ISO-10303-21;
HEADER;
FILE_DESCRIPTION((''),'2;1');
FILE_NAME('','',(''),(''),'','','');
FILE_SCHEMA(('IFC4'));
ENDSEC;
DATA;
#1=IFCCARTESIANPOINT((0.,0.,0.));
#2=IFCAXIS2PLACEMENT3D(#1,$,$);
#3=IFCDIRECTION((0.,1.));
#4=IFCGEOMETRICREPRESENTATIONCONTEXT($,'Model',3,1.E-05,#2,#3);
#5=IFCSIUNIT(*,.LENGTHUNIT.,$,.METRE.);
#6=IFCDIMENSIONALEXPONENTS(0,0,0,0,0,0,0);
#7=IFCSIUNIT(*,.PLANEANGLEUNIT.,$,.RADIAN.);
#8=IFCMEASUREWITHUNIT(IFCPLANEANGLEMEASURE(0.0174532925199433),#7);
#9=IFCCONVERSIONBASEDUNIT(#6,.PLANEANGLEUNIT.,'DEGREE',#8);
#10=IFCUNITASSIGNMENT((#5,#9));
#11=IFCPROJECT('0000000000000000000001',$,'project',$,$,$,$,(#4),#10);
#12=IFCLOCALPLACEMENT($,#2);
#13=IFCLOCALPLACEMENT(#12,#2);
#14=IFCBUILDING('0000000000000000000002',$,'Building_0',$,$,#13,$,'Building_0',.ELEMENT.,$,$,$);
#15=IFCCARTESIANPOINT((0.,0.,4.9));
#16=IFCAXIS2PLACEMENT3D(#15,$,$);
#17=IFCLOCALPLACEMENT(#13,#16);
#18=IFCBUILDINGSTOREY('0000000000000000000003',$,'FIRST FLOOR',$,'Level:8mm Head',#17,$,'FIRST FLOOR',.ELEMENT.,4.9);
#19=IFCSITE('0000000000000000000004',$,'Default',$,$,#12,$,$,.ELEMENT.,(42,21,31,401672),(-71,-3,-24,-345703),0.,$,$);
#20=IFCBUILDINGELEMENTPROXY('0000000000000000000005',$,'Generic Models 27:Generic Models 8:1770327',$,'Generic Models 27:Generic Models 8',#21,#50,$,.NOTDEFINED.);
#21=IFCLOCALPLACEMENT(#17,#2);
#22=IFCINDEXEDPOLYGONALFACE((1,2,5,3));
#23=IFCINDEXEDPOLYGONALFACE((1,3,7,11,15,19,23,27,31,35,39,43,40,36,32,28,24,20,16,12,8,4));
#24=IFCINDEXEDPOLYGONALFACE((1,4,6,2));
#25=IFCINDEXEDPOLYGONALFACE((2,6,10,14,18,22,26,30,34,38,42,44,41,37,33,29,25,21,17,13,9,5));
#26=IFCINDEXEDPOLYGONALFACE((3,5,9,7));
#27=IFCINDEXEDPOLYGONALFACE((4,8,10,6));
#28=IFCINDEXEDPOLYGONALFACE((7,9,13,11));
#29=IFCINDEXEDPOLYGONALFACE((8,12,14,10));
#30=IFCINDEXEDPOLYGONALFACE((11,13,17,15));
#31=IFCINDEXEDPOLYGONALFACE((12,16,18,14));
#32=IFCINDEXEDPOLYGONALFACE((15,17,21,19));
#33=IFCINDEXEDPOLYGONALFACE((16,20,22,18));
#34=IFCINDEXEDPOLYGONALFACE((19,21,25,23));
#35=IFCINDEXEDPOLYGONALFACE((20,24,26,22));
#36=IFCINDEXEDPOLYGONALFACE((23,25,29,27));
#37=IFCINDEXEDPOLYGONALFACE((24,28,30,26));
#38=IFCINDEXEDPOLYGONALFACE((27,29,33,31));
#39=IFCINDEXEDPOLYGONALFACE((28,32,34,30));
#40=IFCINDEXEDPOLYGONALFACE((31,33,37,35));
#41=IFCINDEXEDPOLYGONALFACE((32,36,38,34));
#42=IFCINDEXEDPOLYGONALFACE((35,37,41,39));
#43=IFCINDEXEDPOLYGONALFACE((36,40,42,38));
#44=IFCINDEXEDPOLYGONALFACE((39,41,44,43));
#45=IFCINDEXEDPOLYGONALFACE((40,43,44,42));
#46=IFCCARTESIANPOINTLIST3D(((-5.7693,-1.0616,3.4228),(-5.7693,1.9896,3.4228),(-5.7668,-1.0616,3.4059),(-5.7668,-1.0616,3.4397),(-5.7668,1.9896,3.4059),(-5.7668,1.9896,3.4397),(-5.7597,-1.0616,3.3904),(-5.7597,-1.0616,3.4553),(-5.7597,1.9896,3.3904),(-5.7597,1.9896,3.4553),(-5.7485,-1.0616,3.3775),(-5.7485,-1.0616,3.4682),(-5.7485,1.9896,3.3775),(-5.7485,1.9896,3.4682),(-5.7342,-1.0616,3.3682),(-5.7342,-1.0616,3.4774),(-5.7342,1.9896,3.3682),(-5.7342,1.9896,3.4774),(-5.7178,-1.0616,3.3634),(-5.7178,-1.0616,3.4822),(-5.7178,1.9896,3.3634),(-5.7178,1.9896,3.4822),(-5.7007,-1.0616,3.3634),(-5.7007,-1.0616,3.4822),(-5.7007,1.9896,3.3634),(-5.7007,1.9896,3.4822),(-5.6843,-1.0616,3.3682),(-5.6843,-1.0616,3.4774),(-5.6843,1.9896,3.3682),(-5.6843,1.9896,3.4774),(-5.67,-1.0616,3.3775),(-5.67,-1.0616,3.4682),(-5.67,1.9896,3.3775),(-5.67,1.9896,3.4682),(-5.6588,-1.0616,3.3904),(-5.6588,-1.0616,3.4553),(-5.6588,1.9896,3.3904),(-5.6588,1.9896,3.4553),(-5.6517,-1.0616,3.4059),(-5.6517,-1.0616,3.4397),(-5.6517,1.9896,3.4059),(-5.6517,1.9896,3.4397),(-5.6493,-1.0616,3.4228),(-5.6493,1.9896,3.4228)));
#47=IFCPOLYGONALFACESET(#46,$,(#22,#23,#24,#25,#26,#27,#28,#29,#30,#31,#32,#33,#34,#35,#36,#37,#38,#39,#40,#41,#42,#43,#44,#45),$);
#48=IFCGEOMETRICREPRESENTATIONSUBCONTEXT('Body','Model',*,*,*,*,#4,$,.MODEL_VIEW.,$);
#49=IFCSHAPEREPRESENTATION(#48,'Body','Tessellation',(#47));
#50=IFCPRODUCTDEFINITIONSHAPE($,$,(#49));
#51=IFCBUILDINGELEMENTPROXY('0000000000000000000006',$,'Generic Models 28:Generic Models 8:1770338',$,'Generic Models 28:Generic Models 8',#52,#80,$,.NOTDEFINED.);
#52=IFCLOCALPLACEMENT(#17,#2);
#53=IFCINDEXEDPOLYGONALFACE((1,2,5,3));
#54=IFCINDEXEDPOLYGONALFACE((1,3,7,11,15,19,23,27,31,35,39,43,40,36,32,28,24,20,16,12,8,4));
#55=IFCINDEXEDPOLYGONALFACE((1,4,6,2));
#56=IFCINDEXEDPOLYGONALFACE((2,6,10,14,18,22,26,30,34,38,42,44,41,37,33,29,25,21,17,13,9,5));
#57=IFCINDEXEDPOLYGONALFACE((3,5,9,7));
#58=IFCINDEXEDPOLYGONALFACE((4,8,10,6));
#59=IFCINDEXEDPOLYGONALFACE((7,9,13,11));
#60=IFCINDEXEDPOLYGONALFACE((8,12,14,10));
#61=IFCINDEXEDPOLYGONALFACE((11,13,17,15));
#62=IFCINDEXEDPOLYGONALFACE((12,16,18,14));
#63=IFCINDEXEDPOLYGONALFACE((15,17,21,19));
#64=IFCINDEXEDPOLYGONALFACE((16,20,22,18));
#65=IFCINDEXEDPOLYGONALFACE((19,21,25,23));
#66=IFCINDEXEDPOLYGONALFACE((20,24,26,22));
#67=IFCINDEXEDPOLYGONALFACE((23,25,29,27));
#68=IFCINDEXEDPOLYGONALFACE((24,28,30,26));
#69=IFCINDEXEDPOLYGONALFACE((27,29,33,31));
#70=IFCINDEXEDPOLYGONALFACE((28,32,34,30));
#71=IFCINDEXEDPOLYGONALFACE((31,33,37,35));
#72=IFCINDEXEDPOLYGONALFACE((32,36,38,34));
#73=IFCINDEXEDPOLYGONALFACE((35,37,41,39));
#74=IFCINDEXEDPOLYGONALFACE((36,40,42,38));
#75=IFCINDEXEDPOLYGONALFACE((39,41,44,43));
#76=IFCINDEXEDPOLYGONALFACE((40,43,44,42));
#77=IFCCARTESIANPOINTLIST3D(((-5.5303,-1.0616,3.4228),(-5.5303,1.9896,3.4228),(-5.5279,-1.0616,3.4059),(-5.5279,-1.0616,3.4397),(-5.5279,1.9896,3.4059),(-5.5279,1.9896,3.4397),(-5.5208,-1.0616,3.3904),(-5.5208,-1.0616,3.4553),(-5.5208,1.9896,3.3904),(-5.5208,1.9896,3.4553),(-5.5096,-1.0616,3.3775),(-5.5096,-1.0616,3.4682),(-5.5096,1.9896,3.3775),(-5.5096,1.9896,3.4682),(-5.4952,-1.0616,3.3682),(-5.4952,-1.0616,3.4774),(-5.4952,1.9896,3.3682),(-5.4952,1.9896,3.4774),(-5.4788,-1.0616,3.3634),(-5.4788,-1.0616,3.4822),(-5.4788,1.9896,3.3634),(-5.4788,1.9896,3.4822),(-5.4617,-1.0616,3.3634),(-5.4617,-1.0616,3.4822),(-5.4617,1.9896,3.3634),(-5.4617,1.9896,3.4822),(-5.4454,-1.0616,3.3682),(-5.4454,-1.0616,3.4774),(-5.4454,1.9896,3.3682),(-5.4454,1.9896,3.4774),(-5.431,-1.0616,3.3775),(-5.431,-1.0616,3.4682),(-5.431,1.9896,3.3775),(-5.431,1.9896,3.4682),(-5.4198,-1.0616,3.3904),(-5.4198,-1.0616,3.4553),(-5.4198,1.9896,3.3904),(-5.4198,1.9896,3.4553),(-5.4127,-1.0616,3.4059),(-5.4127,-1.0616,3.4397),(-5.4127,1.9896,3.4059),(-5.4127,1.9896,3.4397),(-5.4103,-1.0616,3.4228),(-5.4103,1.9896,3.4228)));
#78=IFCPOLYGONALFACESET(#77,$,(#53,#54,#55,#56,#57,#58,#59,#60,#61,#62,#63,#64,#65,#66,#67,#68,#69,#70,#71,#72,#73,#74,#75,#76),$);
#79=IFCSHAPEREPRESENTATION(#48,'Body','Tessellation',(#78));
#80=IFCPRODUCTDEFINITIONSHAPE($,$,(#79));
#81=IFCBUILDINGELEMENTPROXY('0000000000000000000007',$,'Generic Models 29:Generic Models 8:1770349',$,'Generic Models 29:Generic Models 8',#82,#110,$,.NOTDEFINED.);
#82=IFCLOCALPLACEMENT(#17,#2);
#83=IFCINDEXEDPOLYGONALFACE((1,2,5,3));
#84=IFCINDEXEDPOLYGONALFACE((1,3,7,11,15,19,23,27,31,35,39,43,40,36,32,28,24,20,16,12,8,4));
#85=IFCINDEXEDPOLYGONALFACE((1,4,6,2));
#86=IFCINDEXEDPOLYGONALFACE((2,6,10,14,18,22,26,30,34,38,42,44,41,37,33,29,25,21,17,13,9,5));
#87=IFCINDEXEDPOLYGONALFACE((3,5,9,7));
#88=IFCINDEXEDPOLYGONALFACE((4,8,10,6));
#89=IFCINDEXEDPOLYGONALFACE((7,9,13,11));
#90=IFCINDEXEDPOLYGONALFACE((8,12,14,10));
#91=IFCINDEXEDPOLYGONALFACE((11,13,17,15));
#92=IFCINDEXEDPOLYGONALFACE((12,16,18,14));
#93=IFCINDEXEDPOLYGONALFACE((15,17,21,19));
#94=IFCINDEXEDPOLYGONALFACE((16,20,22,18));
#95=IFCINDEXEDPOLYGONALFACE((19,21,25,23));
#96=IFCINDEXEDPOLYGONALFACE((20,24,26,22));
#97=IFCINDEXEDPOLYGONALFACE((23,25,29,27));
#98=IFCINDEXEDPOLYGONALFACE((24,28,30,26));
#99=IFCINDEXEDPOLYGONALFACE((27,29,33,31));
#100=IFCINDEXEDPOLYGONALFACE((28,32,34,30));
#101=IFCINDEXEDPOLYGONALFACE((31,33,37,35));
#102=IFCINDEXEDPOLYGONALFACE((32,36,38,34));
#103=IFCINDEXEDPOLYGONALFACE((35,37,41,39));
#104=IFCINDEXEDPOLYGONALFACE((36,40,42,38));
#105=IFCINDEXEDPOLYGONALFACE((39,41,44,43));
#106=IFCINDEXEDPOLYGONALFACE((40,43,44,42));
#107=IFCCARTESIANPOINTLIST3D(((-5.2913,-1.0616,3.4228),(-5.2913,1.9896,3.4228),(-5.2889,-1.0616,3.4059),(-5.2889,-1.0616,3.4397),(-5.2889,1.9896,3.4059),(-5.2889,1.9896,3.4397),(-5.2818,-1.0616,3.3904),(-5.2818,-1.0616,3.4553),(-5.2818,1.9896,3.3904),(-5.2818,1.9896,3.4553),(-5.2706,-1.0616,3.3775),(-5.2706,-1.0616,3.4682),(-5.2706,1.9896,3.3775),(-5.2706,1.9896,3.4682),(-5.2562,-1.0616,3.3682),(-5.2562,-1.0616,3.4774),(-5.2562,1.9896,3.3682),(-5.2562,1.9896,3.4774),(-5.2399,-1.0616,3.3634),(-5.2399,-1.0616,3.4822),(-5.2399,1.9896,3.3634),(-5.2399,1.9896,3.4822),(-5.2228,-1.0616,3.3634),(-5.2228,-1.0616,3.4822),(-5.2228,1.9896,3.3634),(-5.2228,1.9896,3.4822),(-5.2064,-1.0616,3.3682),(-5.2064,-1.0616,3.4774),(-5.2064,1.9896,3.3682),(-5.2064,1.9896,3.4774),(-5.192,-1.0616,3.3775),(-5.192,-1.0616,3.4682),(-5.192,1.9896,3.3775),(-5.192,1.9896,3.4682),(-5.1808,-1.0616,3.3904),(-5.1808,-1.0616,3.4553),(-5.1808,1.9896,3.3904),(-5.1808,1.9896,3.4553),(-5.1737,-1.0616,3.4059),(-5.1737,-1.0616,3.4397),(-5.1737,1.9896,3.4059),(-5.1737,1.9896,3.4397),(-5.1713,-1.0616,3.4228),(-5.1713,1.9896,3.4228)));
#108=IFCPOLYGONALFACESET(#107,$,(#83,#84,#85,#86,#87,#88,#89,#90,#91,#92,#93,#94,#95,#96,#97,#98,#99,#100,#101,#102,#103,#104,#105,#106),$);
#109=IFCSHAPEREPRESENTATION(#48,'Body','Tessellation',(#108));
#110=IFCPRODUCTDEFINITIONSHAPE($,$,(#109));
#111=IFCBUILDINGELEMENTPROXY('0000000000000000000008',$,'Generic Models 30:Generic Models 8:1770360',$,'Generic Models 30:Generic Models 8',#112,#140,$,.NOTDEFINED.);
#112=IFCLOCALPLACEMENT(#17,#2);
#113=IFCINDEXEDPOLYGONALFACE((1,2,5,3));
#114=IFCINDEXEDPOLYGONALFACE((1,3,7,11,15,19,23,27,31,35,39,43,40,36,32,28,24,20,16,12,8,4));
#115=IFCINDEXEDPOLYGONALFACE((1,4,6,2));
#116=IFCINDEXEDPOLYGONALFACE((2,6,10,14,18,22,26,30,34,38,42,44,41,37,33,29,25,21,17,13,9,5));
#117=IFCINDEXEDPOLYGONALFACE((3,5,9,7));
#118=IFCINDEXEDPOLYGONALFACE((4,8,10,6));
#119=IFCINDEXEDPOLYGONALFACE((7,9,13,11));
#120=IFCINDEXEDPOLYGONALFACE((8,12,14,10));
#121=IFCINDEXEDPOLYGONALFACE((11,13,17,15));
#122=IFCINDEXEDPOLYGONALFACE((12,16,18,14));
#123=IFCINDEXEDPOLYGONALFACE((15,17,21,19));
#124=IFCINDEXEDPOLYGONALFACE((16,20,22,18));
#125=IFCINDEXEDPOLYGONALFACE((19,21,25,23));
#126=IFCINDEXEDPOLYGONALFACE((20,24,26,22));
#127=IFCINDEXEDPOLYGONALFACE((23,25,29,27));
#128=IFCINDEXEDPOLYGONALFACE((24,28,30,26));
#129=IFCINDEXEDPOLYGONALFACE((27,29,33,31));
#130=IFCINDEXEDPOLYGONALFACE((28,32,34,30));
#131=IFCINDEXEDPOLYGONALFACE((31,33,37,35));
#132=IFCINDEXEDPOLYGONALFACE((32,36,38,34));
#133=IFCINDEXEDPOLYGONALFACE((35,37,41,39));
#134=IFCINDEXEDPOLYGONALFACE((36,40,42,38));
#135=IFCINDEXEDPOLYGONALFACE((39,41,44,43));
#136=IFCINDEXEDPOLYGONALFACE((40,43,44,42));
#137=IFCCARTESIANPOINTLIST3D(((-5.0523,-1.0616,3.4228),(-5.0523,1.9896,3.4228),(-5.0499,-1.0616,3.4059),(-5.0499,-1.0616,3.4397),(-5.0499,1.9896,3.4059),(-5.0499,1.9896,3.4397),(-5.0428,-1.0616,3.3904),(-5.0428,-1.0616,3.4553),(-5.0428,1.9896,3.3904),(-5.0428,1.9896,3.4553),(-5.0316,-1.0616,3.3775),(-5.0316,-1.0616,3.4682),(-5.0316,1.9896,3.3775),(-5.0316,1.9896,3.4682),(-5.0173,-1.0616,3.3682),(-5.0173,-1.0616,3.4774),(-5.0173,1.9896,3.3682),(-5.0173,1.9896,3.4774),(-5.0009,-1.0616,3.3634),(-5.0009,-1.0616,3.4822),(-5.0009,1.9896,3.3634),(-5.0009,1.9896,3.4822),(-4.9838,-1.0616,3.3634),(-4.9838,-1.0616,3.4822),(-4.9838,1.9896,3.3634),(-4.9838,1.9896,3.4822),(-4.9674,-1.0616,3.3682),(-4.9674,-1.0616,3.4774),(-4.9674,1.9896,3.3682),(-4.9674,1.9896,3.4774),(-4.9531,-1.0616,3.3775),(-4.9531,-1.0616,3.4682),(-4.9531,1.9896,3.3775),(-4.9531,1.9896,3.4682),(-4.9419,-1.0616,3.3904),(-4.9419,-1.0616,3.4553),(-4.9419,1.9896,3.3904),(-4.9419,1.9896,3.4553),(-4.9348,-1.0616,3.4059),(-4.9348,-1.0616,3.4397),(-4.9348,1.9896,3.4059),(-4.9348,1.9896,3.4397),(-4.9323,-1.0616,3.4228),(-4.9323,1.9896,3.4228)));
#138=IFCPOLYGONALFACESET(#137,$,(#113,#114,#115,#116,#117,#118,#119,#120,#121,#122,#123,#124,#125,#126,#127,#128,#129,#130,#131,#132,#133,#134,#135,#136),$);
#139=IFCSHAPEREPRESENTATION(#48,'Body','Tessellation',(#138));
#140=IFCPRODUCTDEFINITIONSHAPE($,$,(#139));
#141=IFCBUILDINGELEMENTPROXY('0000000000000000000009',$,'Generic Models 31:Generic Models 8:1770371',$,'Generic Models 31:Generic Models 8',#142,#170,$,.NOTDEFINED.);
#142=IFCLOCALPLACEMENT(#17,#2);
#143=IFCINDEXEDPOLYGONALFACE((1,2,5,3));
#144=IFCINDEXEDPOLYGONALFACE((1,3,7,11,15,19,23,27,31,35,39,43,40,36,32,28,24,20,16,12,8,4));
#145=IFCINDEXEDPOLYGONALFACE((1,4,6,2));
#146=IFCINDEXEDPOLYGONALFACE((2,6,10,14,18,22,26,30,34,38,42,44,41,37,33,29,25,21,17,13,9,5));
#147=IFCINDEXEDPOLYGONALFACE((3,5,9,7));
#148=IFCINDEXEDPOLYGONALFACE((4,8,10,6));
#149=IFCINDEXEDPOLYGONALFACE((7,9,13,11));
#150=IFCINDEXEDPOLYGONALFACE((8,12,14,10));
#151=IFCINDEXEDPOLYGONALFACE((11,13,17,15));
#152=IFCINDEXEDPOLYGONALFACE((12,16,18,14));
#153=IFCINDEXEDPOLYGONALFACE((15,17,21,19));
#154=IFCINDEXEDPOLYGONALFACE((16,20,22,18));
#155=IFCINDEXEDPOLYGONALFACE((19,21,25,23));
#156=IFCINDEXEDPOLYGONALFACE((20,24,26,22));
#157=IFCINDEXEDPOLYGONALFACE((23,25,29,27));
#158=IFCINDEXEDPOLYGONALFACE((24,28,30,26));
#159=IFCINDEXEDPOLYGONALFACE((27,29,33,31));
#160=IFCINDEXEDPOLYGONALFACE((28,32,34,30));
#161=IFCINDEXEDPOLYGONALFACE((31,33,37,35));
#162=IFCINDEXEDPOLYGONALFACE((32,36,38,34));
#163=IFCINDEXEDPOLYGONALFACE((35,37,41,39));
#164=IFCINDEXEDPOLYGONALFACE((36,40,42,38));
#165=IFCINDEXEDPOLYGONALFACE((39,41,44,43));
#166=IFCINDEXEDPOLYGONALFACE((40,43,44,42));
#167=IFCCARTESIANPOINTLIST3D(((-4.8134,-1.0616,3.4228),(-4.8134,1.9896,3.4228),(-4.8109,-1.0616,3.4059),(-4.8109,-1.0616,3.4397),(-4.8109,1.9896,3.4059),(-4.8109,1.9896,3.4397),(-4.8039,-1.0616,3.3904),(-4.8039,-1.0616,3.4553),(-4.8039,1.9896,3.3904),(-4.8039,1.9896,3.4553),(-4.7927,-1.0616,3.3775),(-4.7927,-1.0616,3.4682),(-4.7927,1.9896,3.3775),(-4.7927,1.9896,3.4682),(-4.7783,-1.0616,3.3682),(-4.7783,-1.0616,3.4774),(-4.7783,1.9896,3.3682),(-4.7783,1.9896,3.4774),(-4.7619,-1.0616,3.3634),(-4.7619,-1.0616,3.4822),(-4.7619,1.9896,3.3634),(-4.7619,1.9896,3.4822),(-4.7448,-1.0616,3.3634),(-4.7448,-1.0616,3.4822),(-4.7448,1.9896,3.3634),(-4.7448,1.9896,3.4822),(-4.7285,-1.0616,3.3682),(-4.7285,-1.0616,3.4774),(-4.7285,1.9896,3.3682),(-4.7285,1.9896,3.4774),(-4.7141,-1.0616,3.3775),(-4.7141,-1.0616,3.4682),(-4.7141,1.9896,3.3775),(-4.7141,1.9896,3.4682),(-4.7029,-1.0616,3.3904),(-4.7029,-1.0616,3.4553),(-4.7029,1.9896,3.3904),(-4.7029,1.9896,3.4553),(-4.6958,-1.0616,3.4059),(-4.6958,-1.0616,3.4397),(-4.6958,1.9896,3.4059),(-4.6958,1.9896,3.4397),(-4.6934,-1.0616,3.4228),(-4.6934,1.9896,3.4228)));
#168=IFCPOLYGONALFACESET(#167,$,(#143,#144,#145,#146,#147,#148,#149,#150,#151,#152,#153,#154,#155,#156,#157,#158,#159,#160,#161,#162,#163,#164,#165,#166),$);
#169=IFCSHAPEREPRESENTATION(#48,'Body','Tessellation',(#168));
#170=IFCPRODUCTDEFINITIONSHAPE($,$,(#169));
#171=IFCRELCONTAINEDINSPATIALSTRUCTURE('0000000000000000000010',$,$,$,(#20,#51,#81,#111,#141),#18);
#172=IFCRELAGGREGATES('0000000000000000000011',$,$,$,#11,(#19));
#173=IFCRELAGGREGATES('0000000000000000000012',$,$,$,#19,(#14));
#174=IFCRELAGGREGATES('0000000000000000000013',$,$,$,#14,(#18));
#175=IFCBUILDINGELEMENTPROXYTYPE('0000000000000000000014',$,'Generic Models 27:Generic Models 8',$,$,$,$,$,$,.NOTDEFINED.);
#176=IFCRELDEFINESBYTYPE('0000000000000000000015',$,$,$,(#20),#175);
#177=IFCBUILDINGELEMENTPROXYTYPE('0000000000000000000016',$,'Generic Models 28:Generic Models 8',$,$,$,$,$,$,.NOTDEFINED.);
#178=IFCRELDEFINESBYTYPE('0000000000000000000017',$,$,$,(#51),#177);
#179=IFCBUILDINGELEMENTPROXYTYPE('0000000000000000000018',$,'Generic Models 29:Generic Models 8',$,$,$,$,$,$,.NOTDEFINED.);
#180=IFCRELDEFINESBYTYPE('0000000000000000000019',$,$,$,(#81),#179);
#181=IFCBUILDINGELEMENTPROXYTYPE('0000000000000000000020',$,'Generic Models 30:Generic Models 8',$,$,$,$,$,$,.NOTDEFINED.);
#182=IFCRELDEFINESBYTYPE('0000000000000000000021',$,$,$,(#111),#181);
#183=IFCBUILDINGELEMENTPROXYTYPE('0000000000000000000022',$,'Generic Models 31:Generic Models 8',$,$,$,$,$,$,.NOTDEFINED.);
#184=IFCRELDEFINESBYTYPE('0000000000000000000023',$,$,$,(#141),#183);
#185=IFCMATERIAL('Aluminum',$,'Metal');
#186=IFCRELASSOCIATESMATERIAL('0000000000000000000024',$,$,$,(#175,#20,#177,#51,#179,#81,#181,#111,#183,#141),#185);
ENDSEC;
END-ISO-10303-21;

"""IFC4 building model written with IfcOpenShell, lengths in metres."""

from ifc_helpers import new_model, entity, si_unit, converted_unit, direction, frame, origin, place, context, subcontext, project, spatial, arc, indexed_curve, outline, extrude, source, transform, mapped, material, type_object, type_shapes, element, save


model = new_model("IFC4")

# Units and contexts
model_context = context("Model", 3, precision=1e-05, world=origin(), true_north=direction((0.0, 1.0)))
body_context = subcontext(model_context, "Body", "Model", "MODEL_VIEW")
ifc_project = project(units=[si_unit("LENGTHUNIT", "METRE"), converted_unit("PLANEANGLEUNIT", "DEGREE", entity("IfcPlaneAngleMeasure", 0.0174532925199433), si_unit("PLANEANGLEUNIT", "RADIAN"), dimensions=[0, 0, 0, 0, 0, 0, 0])], contexts=[model_context])

# Site, building, storey
site_placement = place(None, origin())
site = spatial("IfcSite", under=ifc_project, at=site_placement, Name="Default", CompositionType="ELEMENT", RefLatitude=(42, 21, 31, 401672), RefLongitude=(-71, -3, -24, -345703), RefElevation=0.0)
building_placement = place(site_placement, origin())
building = spatial("IfcBuilding", under=site, at=building_placement, Name="Building_0", LongName="Building_0", CompositionType="ELEMENT")
storey_placement = place(building_placement, frame((0.0, 0.0, 4.9)))
storey = spatial("IfcBuildingStorey", under=building, at=storey_placement, Name="FIRST FLOOR", ObjectType="Level:8mm Head", LongName="FIRST FLOOR", CompositionType="ELEMENT", Elevation=4.9)

# Building element proxies
ifc_material = material(Name="Aluminum", Category="Metal")
building_element_proxy_type_1 = type_object("IfcBuildingElementProxyType", Name="Generic Models 27:Generic Models 8", PredefinedType="NOTDEFINED", material=ifc_material)
shared_shape_1 = source(origin(), body_context, "Body", "SweptSolid", [
    extrude(outline(indexed_curve([(-0.06, 0.0), (0.0, -0.06), (0.06, 0.0), (0.0, 0.06)], segments=[arc(1, 2, 3), arc(3, 4, 1)], self_intersect=False)), frame((-5.7093, -1.0616, 8.3228), z_axis=(0.0, 1.0, 0.0), x_axis=(-1.0, 0.0, 0.0)), (0.0, 0.0, 1.0), 3.0512),
])
type_shapes(building_element_proxy_type_1, [shared_shape_1])
proxy_1_placement = place(storey_placement, frame((0.0, 0.0, -4.9)))
element("IfcBuildingElementProxy", 1, at=proxy_1_placement, inside=storey, type_object=building_element_proxy_type_1, material=ifc_material, Name="Generic Models 27:Generic Models 8:1770327", ObjectType="Generic Models 27:Generic Models 8", PredefinedType="NOTDEFINED", context=body_context, shape_type="MappedRepresentation", body=[
    mapped(shared_shape_1, transform((0.0, 0.0, 0.0), scale=1.0)),
])
building_element_proxy_type_2 = type_object("IfcBuildingElementProxyType", Name="Generic Models 28:Generic Models 8", PredefinedType="NOTDEFINED", material=ifc_material)
shared_shape_2 = source(origin(), body_context, "Body", "SweptSolid", [
    extrude(outline(indexed_curve([(-0.06, 0.0), (0.0, -0.06), (0.06, 0.0), (0.0, 0.06)], segments=[arc(1, 2, 3), arc(3, 4, 1)], self_intersect=False)), frame((-5.4703, -1.0616, 8.3228), z_axis=(0.0, 1.0, 0.0), x_axis=(-1.0, 0.0, 0.0)), (0.0, 0.0, 1.0), 3.0512),
])
type_shapes(building_element_proxy_type_2, [shared_shape_2])
proxy_2_placement = place(storey_placement, frame((0.0, 0.0, -4.9)))
element("IfcBuildingElementProxy", 2, at=proxy_2_placement, inside=storey, type_object=building_element_proxy_type_2, material=ifc_material, Name="Generic Models 28:Generic Models 8:1770338", ObjectType="Generic Models 28:Generic Models 8", PredefinedType="NOTDEFINED", context=body_context, shape_type="MappedRepresentation", body=[
    mapped(shared_shape_2, transform((0.0, 0.0, 0.0), scale=1.0)),
])
building_element_proxy_type_3 = type_object("IfcBuildingElementProxyType", Name="Generic Models 29:Generic Models 8", PredefinedType="NOTDEFINED", material=ifc_material)
shared_shape_3 = source(origin(), body_context, "Body", "SweptSolid", [
    extrude(outline(indexed_curve([(-0.06, 0.0), (0.0, -0.06), (0.06, 0.0), (0.0, 0.06)], segments=[arc(1, 2, 3), arc(3, 4, 1)], self_intersect=False)), frame((-5.2313, -1.0616, 8.3228), z_axis=(0.0, 1.0, 0.0), x_axis=(-1.0, 0.0, 0.0)), (0.0, 0.0, 1.0), 3.0512),
])
type_shapes(building_element_proxy_type_3, [shared_shape_3])
proxy_3_placement = place(storey_placement, frame((0.0, 0.0, -4.9)))
element("IfcBuildingElementProxy", 3, at=proxy_3_placement, inside=storey, type_object=building_element_proxy_type_3, material=ifc_material, Name="Generic Models 29:Generic Models 8:1770349", ObjectType="Generic Models 29:Generic Models 8", PredefinedType="NOTDEFINED", context=body_context, shape_type="MappedRepresentation", body=[
    mapped(shared_shape_3, transform((0.0, 0.0, 0.0), scale=1.0)),
])
building_element_proxy_type_4 = type_object("IfcBuildingElementProxyType", Name="Generic Models 30:Generic Models 8", PredefinedType="NOTDEFINED", material=ifc_material)
shared_shape_4 = source(origin(), body_context, "Body", "SweptSolid", [
    extrude(outline(indexed_curve([(-0.06, 0.0), (0.0, -0.06), (0.06, 0.0), (0.0, 0.06)], segments=[arc(1, 2, 3), arc(3, 4, 1)], self_intersect=False)), frame((-4.9923, -1.0616, 8.3228), z_axis=(0.0, 1.0, 0.0), x_axis=(-1.0, 0.0, 0.0)), (0.0, 0.0, 1.0), 3.0512),
])
type_shapes(building_element_proxy_type_4, [shared_shape_4])
proxy_4_placement = place(storey_placement, frame((0.0, 0.0, -4.9)))
element("IfcBuildingElementProxy", 4, at=proxy_4_placement, inside=storey, type_object=building_element_proxy_type_4, material=ifc_material, Name="Generic Models 30:Generic Models 8:1770360", ObjectType="Generic Models 30:Generic Models 8", PredefinedType="NOTDEFINED", context=body_context, shape_type="MappedRepresentation", body=[
    mapped(shared_shape_4, transform((0.0, 0.0, 0.0), scale=1.0)),
])
building_element_proxy_type_5 = type_object("IfcBuildingElementProxyType", Name="Generic Models 31:Generic Models 8", PredefinedType="NOTDEFINED", material=ifc_material)
shared_shape_5 = source(origin(), body_context, "Body", "SweptSolid", [
    extrude(outline(indexed_curve([(-0.06, 0.0), (0.0, -0.06), (0.06, 0.0), (0.0, 0.06)], segments=[arc(1, 2, 3), arc(3, 4, 1)], self_intersect=False)), frame((-4.7534, -1.0616, 8.3228), z_axis=(0.0, 1.0, 0.0), x_axis=(-1.0, 0.0, 0.0)), (0.0, 0.0, 1.0), 3.0512),
])
type_shapes(building_element_proxy_type_5, [shared_shape_5])
proxy_5_placement = place(storey_placement, frame((0.0, 0.0, -4.9)))
element("IfcBuildingElementProxy", 5, at=proxy_5_placement, inside=storey, type_object=building_element_proxy_type_5, material=ifc_material, Name="Generic Models 31:Generic Models 8:1770371", ObjectType="Generic Models 31:Generic Models 8", PredefinedType="NOTDEFINED", context=body_context, shape_type="MappedRepresentation", body=[
    mapped(shared_shape_5, transform((0.0, 0.0, 0.0), scale=1.0)),
])

save(model, "model.ifc")
